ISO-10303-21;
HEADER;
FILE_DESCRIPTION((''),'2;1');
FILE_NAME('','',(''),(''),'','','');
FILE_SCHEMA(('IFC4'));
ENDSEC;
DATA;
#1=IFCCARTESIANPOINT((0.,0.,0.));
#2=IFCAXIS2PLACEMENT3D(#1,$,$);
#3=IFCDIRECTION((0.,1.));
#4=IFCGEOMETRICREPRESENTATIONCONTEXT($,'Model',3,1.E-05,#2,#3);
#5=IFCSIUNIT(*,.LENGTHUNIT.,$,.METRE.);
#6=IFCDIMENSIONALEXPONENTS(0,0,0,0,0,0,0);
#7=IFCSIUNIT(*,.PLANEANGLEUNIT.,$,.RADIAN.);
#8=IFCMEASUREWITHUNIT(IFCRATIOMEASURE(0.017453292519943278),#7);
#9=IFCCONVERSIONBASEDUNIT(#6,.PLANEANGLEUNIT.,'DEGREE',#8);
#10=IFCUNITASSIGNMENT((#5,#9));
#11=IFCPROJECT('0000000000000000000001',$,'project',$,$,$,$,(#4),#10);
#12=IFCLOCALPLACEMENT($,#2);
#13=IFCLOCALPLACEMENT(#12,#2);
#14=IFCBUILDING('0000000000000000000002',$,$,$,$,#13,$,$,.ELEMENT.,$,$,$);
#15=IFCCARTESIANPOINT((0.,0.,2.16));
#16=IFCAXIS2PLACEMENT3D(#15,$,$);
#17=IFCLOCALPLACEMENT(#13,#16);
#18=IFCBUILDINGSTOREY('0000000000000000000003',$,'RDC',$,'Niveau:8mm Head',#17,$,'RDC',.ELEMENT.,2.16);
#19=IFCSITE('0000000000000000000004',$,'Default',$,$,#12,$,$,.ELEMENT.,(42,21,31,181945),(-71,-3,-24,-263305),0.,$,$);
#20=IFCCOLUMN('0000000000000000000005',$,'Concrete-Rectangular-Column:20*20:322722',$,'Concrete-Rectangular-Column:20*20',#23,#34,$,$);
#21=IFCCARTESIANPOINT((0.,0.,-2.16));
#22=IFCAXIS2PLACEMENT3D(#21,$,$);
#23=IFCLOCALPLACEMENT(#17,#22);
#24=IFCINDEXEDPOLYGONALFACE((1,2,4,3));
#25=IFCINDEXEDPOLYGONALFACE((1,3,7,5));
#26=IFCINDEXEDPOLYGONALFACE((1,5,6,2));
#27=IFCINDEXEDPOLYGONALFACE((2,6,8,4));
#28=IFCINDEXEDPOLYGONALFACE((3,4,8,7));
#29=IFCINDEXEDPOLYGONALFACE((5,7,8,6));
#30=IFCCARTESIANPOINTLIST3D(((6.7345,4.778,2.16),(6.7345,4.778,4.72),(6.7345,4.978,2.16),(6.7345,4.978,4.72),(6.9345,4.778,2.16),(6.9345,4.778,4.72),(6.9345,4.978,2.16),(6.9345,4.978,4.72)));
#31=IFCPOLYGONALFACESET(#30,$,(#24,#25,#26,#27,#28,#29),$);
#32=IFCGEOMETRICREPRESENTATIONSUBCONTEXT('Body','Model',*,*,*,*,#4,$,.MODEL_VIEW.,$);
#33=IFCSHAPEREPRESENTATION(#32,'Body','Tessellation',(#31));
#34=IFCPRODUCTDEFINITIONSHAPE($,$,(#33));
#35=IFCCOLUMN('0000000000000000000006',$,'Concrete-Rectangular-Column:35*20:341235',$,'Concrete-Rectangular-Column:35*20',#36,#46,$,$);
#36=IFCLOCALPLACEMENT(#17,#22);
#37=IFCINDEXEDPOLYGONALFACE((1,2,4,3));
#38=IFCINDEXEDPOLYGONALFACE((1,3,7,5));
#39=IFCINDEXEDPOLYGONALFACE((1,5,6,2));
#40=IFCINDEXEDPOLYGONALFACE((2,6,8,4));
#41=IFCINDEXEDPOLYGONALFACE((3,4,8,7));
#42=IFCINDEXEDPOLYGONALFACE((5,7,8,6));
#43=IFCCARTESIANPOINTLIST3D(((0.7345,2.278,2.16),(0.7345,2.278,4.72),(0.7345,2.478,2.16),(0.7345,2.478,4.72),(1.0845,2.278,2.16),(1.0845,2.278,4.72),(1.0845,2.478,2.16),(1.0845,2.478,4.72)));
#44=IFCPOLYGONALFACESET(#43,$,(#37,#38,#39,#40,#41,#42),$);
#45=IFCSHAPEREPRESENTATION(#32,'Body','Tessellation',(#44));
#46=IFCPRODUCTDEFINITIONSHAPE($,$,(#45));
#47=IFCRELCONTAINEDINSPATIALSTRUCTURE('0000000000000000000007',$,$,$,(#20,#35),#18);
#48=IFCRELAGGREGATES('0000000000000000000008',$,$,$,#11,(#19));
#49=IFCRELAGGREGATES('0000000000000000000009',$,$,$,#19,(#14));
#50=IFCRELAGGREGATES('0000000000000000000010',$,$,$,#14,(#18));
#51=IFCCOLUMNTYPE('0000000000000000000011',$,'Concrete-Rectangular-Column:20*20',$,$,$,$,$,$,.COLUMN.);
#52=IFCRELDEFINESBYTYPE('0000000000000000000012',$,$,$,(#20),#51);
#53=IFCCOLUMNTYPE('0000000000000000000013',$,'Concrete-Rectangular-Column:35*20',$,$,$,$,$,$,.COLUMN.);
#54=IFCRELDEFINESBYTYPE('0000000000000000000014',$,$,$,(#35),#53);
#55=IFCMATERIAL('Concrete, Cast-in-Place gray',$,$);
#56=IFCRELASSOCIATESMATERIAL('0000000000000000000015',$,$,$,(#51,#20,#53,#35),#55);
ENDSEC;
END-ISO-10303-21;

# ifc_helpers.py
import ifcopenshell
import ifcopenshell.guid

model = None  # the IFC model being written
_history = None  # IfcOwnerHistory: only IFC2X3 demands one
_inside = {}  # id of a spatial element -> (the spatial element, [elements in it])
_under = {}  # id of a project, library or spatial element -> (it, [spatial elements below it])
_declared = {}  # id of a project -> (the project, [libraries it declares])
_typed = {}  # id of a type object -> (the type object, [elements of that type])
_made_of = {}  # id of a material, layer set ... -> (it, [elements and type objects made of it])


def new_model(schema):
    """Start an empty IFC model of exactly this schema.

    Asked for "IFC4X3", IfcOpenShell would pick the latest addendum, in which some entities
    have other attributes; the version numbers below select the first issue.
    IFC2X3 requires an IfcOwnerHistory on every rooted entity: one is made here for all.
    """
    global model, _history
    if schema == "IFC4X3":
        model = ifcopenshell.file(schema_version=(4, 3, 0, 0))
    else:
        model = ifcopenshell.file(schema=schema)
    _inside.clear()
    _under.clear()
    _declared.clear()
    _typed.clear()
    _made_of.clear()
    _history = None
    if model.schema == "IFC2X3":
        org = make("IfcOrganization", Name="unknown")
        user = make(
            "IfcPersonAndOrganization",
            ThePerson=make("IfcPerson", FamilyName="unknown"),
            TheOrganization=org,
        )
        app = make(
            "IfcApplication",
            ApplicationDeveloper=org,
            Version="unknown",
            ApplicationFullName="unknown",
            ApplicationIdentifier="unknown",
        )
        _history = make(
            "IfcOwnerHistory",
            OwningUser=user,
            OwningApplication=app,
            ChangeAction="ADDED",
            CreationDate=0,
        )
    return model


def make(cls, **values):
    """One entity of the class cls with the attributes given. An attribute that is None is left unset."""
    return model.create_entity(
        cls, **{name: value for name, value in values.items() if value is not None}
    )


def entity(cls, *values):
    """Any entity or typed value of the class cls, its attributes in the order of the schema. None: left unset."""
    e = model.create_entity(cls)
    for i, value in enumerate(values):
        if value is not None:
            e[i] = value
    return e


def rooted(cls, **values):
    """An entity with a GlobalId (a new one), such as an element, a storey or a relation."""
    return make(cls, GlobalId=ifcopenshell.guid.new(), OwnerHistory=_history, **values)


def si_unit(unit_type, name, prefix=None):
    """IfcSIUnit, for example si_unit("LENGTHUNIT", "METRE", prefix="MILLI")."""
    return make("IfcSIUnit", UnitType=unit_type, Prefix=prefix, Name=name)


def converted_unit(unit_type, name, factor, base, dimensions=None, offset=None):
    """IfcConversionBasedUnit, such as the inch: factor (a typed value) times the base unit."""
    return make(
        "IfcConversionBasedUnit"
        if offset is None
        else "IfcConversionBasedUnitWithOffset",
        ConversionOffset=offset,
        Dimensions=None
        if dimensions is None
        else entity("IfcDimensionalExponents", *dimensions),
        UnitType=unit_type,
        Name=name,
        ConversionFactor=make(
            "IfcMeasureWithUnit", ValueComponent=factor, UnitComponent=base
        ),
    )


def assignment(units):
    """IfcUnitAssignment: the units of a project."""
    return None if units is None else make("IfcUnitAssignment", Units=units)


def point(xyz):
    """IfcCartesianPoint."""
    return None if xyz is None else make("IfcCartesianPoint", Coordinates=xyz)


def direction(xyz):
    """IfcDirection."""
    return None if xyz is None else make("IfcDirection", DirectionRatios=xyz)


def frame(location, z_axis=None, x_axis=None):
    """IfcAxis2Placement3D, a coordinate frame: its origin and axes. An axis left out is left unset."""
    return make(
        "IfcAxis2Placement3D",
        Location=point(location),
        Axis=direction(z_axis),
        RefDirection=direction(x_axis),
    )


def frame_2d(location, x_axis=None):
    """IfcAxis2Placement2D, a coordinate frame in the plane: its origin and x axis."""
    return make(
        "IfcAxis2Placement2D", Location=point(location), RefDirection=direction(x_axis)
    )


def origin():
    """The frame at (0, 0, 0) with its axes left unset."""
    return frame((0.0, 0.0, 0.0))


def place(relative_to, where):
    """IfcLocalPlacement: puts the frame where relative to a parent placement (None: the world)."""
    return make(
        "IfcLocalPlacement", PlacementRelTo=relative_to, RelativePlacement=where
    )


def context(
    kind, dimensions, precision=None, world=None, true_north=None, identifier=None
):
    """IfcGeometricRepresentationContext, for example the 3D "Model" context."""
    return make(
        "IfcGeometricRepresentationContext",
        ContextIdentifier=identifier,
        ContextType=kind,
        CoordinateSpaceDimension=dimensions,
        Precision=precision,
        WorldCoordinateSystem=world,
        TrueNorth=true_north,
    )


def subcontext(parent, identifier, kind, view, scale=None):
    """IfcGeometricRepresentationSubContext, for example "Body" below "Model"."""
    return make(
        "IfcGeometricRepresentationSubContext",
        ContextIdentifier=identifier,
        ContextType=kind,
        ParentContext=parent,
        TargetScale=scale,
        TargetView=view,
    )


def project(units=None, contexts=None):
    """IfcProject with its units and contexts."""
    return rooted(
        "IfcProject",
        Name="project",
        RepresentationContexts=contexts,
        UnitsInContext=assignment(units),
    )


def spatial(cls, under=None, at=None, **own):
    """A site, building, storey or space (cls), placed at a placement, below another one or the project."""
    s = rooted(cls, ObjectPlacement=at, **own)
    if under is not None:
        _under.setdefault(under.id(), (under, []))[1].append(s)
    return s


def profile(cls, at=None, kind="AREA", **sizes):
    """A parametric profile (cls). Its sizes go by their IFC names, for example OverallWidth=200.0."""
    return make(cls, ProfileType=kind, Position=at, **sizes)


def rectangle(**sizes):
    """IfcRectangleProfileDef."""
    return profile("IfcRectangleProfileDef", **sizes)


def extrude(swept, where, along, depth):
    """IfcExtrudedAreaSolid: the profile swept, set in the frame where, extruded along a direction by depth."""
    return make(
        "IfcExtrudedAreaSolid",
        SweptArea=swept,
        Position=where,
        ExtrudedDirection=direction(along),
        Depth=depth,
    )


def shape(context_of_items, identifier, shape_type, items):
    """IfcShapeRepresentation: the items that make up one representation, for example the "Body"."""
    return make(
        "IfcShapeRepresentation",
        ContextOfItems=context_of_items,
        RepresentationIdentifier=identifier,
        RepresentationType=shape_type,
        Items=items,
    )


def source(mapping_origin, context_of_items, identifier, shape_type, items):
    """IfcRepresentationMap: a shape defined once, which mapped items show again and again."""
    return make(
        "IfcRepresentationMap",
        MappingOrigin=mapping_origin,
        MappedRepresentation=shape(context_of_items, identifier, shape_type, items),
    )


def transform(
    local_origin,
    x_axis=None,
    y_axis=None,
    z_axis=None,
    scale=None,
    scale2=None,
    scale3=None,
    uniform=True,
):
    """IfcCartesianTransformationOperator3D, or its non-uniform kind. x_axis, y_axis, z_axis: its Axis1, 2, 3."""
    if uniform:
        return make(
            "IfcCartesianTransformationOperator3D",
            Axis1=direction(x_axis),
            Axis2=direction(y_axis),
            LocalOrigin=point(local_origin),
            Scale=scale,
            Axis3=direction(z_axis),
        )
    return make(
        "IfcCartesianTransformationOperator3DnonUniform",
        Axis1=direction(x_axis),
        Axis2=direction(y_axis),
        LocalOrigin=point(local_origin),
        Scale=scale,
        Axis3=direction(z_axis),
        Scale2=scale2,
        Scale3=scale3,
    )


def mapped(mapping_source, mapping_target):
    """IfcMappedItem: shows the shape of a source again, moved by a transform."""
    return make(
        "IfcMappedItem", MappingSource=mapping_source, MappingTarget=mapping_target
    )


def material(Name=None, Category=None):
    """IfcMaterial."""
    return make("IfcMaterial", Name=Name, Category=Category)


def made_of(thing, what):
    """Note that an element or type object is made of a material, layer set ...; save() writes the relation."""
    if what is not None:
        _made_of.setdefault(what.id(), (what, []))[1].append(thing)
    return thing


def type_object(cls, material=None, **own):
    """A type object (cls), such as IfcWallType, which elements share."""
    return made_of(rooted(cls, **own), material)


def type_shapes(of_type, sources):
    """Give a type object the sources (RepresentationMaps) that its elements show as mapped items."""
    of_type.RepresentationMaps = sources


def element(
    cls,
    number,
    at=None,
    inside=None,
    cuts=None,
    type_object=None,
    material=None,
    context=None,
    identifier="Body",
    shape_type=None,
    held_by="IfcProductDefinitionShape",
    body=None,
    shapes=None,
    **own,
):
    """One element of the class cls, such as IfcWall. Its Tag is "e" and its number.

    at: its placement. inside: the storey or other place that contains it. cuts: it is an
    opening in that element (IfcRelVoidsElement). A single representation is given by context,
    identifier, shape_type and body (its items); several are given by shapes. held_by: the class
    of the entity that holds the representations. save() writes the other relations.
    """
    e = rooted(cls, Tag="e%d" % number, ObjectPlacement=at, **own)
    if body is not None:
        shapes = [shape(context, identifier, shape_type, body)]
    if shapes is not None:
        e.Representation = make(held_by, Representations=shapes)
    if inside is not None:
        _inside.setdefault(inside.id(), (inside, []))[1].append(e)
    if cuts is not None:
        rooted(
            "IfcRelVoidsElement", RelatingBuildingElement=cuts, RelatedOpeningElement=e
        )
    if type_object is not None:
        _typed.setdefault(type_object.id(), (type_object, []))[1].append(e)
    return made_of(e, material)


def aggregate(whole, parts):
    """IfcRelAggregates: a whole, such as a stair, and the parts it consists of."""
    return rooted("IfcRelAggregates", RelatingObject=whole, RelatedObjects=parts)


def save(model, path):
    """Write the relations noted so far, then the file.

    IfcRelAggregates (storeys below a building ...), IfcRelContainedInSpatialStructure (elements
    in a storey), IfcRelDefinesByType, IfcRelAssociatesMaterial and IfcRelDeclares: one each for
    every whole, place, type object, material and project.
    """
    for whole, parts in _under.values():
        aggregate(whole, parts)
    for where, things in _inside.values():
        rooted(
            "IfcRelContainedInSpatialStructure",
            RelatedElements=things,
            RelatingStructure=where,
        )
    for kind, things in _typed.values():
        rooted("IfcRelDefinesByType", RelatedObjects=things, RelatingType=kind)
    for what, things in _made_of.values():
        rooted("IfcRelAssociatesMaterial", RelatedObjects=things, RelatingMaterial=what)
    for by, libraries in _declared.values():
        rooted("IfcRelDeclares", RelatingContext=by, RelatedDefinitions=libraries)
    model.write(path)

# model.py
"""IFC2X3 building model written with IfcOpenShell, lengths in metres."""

from ifc_helpers import new_model, entity, si_unit, converted_unit, direction, frame, frame_2d, origin, place, context, subcontext, project, spatial, rectangle, extrude, source, transform, mapped, material, type_object, type_shapes, element, save


model = new_model("IFC2X3")

# Units and contexts
model_context = context("Model", 3, precision=1e-05, world=origin(), true_north=direction((0.0, 1.0)))
body_context = subcontext(model_context, "Body", "Model", "MODEL_VIEW")
ifc_project = project(units=[si_unit("LENGTHUNIT", "METRE"), converted_unit("PLANEANGLEUNIT", "DEGREE", entity("IfcRatioMeasure", 0.017453292519943278), si_unit("PLANEANGLEUNIT", "RADIAN"), dimensions=[0, 0, 0, 0, 0, 0, 0])], contexts=[model_context])

# Site, building, storey
site_placement = place(None, origin())
site = spatial("IfcSite", under=ifc_project, at=site_placement, Name="Default", CompositionType="ELEMENT", RefLatitude=(42, 21, 31, 181945), RefLongitude=(-71, -3, -24, -263305), RefElevation=0.0)
building_placement = place(site_placement, origin())
building = spatial("IfcBuilding", under=site, at=building_placement, CompositionType="ELEMENT")
storey_placement = place(building_placement, frame((0.0, 0.0, 2.16)))
storey = spatial("IfcBuildingStorey", under=building, at=storey_placement, Name="RDC", ObjectType="Niveau:8mm Head", LongName="RDC", CompositionType="ELEMENT", Elevation=2.16)

# Columns
ifc_material_1 = material(Name="Concrete, Cast-in-Place gray")
column_type_1 = type_object("IfcColumnType", Name="Concrete-Rectangular-Column:20*20", PredefinedType="COLUMN", material=ifc_material_1)
shared_shape_1 = source(origin(), body_context, "Body", "SweptSolid", [
    extrude(rectangle(XDim=0.2, YDim=0.2, at=frame_2d((0.0, 0.0), x_axis=(1.0, 0.0))), frame((6.8345, 4.878, 2.16), z_axis=(0.0, 0.0, 1.0), x_axis=(0.0, -1.0, 0.0)), (0.0, 0.0, 1.0), 2.56),
])
type_shapes(column_type_1, [shared_shape_1])
column_1_placement = place(storey_placement, frame((0.0, 0.0, -2.16)))
element("IfcColumn", 1, at=column_1_placement, inside=storey, type_object=column_type_1, material=ifc_material_1, Name="Concrete-Rectangular-Column:20*20:322722", ObjectType="Concrete-Rectangular-Column:20*20", context=body_context, shape_type="MappedRepresentation", body=[
    mapped(shared_shape_1, transform((0.0, 0.0, 0.0), scale=1.0)),
])
column_type_2 = type_object("IfcColumnType", Name="Concrete-Rectangular-Column:35*20", PredefinedType="COLUMN", material=ifc_material_1)
shared_shape_2 = source(origin(), body_context, "Body", "SweptSolid", [
    extrude(rectangle(XDim=0.2, YDim=0.35, at=frame_2d((0.0, 0.0), x_axis=(1.0, 0.0))), frame((0.9095, 2.378, 2.16), z_axis=(0.0, 0.0, 1.0), x_axis=(0.0, -1.0, 0.0)), (0.0, 0.0, 1.0), 2.56),
])
type_shapes(column_type_2, [shared_shape_2])
column_2_placement = place(storey_placement, frame((0.0, 0.0, -2.16)))
element("IfcColumn", 2, at=column_2_placement, inside=storey, type_object=column_type_2, material=ifc_material_1, Name="Concrete-Rectangular-Column:35*20:341235", ObjectType="Concrete-Rectangular-Column:35*20", context=body_context, shape_type="MappedRepresentation", body=[
    mapped(shared_shape_2, transform((0.0, 0.0, 0.0), scale=1.0)),
])

save(model, "model.ifc")
